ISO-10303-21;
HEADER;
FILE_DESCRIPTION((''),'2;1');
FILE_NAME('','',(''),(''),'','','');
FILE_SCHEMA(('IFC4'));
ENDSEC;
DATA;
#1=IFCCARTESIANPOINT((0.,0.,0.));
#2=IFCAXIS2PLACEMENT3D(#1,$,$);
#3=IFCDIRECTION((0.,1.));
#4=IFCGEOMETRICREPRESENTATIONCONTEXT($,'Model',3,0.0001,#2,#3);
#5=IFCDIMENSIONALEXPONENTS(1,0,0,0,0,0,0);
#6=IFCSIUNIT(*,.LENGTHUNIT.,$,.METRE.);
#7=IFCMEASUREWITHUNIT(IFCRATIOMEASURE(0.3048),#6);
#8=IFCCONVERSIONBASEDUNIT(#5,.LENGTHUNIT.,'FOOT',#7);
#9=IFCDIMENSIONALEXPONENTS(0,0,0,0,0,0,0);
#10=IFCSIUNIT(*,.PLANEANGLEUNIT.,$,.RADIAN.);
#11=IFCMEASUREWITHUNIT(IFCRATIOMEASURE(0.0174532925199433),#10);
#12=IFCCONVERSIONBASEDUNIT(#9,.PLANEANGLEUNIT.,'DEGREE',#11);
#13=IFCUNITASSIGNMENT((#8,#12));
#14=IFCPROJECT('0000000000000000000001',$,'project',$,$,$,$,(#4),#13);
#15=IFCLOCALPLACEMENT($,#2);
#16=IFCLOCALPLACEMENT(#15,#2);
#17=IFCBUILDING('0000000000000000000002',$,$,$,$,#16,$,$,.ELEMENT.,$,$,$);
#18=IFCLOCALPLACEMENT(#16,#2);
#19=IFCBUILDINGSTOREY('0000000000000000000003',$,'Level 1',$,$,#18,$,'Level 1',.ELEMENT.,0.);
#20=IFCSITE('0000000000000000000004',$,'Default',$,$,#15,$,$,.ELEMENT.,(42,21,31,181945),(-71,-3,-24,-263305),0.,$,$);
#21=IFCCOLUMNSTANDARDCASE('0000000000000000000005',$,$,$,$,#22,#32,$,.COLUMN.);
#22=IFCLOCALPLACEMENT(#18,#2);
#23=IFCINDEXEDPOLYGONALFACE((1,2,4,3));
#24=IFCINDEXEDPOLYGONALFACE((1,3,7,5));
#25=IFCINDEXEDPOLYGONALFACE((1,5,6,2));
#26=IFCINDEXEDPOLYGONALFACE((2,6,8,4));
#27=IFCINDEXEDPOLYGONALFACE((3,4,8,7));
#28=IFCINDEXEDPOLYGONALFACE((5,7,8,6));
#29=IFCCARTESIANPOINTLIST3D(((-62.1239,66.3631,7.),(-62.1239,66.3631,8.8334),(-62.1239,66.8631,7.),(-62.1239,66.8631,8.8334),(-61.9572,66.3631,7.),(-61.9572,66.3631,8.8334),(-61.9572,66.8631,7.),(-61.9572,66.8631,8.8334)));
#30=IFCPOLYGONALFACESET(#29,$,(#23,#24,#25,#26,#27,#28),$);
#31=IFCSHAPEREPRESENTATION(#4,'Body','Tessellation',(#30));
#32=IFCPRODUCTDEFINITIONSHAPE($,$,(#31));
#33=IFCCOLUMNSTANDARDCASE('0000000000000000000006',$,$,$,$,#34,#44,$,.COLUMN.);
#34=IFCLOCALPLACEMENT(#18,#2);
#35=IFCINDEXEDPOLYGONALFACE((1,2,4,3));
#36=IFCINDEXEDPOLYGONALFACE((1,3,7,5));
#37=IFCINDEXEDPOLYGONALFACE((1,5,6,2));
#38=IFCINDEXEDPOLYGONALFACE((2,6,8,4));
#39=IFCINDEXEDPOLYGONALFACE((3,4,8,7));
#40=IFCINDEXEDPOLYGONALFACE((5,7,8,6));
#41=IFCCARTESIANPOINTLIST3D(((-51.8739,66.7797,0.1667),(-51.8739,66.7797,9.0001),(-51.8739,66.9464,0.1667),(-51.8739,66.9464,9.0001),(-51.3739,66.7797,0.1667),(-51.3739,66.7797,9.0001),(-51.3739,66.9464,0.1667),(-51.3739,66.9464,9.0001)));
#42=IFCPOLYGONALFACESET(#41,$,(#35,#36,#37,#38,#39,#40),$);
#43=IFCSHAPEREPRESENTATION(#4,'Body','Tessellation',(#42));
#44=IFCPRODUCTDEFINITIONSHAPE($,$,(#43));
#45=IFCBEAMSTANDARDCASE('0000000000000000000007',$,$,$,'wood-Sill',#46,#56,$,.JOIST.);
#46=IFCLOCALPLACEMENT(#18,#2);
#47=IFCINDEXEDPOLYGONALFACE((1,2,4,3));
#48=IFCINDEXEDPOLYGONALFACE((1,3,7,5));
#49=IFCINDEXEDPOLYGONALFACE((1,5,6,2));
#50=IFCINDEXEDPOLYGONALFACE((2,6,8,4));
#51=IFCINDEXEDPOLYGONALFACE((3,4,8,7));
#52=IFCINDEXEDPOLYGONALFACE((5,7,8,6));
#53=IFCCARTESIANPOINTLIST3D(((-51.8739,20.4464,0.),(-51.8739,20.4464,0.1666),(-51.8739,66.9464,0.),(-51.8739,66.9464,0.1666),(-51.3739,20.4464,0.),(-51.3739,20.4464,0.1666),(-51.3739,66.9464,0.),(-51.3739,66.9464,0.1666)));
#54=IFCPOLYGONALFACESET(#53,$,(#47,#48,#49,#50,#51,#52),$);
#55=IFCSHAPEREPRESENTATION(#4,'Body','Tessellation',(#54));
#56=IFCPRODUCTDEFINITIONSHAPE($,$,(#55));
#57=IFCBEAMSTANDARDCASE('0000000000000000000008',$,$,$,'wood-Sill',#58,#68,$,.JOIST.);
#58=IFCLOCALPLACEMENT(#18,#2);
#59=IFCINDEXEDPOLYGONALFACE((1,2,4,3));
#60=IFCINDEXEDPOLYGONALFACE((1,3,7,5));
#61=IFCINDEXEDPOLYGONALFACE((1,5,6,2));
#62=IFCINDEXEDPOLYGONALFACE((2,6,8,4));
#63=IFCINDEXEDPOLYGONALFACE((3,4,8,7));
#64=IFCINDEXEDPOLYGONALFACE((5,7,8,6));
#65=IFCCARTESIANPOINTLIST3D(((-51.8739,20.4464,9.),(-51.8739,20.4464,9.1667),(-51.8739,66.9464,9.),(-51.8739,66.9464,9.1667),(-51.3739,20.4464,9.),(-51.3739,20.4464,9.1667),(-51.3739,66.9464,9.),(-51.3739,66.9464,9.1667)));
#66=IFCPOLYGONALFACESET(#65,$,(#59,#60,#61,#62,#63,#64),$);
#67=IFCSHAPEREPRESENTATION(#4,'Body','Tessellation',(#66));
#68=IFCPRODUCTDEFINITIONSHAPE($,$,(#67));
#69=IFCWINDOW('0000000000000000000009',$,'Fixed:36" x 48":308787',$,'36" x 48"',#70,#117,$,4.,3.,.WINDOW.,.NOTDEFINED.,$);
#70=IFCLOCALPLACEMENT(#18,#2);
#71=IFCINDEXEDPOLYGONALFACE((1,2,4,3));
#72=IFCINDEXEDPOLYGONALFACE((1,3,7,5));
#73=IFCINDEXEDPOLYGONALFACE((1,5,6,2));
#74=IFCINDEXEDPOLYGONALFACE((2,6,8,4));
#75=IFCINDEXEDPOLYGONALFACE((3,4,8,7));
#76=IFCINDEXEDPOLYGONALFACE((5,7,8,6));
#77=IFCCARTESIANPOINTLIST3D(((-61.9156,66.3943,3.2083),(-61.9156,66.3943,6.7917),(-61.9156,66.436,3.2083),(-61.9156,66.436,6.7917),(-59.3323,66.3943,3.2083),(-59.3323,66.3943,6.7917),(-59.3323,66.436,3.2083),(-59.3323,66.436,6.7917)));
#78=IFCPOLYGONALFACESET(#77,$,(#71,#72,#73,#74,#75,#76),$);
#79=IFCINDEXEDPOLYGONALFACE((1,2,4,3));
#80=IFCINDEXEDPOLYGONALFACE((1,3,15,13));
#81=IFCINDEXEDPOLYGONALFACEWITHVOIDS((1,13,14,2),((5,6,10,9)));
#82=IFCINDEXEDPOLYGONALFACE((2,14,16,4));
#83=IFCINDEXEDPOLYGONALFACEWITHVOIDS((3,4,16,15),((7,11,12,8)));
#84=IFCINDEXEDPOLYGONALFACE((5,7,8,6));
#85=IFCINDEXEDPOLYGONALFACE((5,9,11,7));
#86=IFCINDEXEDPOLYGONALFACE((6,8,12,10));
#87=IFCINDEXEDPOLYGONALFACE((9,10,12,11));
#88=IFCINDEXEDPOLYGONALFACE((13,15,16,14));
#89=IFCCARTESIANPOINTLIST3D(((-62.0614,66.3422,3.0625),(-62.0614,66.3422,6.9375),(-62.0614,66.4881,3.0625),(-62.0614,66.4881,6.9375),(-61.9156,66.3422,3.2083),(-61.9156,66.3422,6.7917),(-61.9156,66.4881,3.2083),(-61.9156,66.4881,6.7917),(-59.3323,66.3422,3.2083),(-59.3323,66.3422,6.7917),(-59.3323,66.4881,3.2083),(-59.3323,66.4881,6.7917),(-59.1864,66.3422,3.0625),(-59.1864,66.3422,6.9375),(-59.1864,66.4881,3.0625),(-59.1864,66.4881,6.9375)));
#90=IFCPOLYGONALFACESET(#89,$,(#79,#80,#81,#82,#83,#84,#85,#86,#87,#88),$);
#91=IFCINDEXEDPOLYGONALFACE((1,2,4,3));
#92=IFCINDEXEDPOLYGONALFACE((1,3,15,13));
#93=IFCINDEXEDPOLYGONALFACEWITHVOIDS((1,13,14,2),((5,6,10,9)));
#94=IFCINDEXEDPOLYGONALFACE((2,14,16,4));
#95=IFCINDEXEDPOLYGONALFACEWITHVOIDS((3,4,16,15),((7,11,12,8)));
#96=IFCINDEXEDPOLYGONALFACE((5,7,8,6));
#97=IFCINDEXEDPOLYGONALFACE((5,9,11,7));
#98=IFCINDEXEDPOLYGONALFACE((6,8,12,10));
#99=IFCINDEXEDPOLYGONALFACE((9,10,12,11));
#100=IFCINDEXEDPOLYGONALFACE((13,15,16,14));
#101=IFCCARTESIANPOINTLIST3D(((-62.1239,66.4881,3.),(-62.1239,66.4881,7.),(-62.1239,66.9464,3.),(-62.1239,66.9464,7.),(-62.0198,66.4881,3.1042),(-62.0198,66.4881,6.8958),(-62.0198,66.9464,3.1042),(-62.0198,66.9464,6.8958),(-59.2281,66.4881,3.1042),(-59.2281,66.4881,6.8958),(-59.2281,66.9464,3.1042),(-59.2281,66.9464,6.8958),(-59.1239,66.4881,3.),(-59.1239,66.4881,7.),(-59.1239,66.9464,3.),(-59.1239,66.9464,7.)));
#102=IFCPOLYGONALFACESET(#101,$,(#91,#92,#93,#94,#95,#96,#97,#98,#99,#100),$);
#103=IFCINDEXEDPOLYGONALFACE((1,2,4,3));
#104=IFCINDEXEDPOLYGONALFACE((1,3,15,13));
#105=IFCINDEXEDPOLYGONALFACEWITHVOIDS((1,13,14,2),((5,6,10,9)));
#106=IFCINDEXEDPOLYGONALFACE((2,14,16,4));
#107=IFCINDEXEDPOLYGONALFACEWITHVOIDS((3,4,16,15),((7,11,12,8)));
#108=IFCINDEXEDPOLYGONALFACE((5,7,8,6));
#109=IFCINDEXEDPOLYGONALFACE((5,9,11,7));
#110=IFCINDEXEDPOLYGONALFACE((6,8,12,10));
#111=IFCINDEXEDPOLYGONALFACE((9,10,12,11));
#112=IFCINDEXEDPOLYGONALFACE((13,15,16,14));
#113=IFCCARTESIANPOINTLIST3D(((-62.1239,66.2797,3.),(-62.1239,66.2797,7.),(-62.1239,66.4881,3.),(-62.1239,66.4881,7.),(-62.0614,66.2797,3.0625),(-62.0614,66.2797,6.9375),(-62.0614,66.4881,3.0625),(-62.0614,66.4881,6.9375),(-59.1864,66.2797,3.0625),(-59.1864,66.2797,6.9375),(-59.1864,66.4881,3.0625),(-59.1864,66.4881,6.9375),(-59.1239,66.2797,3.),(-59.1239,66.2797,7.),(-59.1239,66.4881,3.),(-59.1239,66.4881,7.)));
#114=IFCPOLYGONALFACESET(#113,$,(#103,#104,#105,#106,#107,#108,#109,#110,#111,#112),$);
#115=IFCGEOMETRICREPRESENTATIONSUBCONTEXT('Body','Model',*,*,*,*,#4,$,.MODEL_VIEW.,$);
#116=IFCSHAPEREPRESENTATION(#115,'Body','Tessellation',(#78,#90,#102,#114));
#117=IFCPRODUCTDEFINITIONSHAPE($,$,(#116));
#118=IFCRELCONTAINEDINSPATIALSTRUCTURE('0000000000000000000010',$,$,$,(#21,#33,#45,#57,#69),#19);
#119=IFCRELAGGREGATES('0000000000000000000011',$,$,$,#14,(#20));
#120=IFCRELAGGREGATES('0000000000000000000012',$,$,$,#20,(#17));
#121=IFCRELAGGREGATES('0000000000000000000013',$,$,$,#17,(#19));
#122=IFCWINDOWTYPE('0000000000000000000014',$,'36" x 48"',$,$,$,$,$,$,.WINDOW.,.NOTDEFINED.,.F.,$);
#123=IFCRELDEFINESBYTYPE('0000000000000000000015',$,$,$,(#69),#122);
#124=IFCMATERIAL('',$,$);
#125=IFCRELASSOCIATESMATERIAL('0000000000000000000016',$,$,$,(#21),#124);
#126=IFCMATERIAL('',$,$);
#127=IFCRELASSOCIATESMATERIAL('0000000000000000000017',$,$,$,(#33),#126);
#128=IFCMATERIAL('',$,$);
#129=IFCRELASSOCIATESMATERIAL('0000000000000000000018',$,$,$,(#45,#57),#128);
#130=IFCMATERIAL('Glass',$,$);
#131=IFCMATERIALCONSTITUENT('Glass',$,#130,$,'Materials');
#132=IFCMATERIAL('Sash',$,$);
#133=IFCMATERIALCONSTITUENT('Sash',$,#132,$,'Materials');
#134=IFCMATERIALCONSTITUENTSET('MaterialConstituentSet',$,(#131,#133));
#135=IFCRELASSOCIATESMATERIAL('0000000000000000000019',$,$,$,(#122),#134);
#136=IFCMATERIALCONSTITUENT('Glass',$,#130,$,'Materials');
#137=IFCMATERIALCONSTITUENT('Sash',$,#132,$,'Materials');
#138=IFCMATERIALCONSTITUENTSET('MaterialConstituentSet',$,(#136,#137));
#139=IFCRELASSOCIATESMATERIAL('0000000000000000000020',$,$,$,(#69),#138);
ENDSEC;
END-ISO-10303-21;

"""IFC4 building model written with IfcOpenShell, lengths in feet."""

from ifc_helpers import new_model, entity, si_unit, converted_unit, direction, frame, frame_2d, origin, origin_with_axes, place, context, subcontext, project, spatial, polyline, rectangle, outline, extrude, source, transform, mapped, material, constituent, constituent_set, type_object, type_shapes, element, save


model = new_model("IFC4")

# Units and contexts
model_context = context("Model", 3, precision=0.0001, world=origin(), true_north=direction((0.0, 1.0)))
body_context = subcontext(model_context, "Body", "Model", "MODEL_VIEW")
ifc_project = project(units=[converted_unit("LENGTHUNIT", "FOOT", entity("IfcRatioMeasure", 0.3048), si_unit("LENGTHUNIT", "METRE"), dimensions=[1, 0, 0, 0, 0, 0, 0]), converted_unit("PLANEANGLEUNIT", "DEGREE", entity("IfcRatioMeasure", 0.0174532925199433), si_unit("PLANEANGLEUNIT", "RADIAN"), dimensions=[0, 0, 0, 0, 0, 0, 0])], contexts=[model_context])

# Site, building, storey
site_placement = place(None, origin())
site = spatial("IfcSite", under=ifc_project, at=site_placement, Name="Default", CompositionType="ELEMENT", RefLatitude=(42, 21, 31, 181945), RefLongitude=(-71, -3, -24, -263305), RefElevation=0.0)
building_placement = place(site_placement, origin())
building = spatial("IfcBuilding", under=site, at=building_placement, CompositionType="ELEMENT")
storey_placement = place(building_placement, origin())
storey = spatial("IfcBuildingStorey", under=building, at=storey_placement, Name="Level 1", LongName="Level 1", CompositionType="ELEMENT", Elevation=0.0)

# Columns
ifc_material_1 = material(Name="")
placement_1 = place(storey_placement, frame((-69.9573, 66.6131, 0.0)))
ifc_material_2 = material(Name="")
for number, where, z_axis, x_axis in (
    (1, (7.9167, 0.0, 7.0), (0.0, 0.0, 1.0), (1.0, 0.0, 0.0)),
):
    element("IfcColumnStandardCase", number, at=place(placement_1, frame(where, z_axis=z_axis, x_axis=x_axis)), inside=storey, material=ifc_material_2, PredefinedType="COLUMN", context=model_context, shape_type="SweptSolid", body=[
        extrude(rectangle(XDim=0.1667, YDim=0.5), origin(), (0.0, 0.0, 1.0), 1.8334),
    ])
placement_2 = place(storey_placement, frame((-51.6239, 66.9464, 0.0), z_axis=(0.0, 0.0, 1.0), x_axis=(0.0, -1.0, 0.0)))
for number, where, z_axis, x_axis in (
    (2, (0.0833, 0.0, 0.1667), (0.0, 0.0, 1.0), (1.0, 0.0, 0.0)),
):
    element("IfcColumnStandardCase", number, at=place(placement_2, frame(where, z_axis=z_axis, x_axis=x_axis)), inside=storey, material=ifc_material_1, PredefinedType="COLUMN", context=model_context, shape_type="SweptSolid", body=[
        extrude(rectangle(XDim=0.1667, YDim=0.5), origin(), (0.0, 0.0, 1.0), 8.8334),
    ])

# Beams
ifc_material_3 = material(Name="")
for number, where, z_axis, x_axis in (
    (3, (0.0, 0.0, 0.0833), (1.0, 0.0, 0.0), (0.0, 0.0, 1.0)),
    (4, (0.0, 0.0, 9.0834), (1.0, 0.0, 0.0), (0.0, 0.0, 1.0)),
):
    element("IfcBeamStandardCase", number, at=place(placement_2, frame(where, z_axis=z_axis, x_axis=x_axis)), inside=storey, material=ifc_material_3, ObjectType="wood-Sill", PredefinedType="JOIST", context=model_context, shape_type="SweptSolid", body=[
        extrude(rectangle(XDim=0.1667, YDim=0.5), origin_with_axes(), (0.0, 0.0, 1.0), 46.5),
    ])

# Window
ifc_material_4 = material(Name="Glass")
ifc_constituent_1 = constituent(ifc_material_4, Name="Glass", Category="Materials")
ifc_material_5 = material(Name="Sash")
ifc_constituent_2 = constituent(ifc_material_5, Name="Sash", Category="Materials")
ifc_constituent_set_1 = constituent_set(constituents=[ifc_constituent_1, ifc_constituent_2], Name="MaterialConstituentSet")
ifc_constituent_3 = constituent(ifc_material_4, Name="Glass", Category="Materials")
ifc_constituent_4 = constituent(ifc_material_5, Name="Sash", Category="Materials")
ifc_constituent_set_2 = constituent_set(constituents=[ifc_constituent_3, ifc_constituent_4], Name="MaterialConstituentSet")
window_type = type_object("IfcWindowType", Name="36\" x 48\"", ParameterTakesPrecedence=False, PartitioningType="NOTDEFINED", PredefinedType="WINDOW", material=ifc_constituent_set_2)
shared_shape = source(origin(), body_context, "Body", "SweptSolid", [
    extrude(rectangle(XDim=0.0417, YDim=2.5833, at=frame_2d((0.0, 0.0), x_axis=(1.0, 0.0))), frame((1.5, 0.5312, 0.2083), z_axis=(0.0, 0.0, 1.0), x_axis=(0.0, 1.0, 0.0)), (0.0, 0.0, 1.0), 3.5833),
    extrude(outline(polyline([(-1.4375, -1.9375), (1.4375, -1.9375), (1.4375, 1.9375), (-1.4375, 1.9375), (-1.4375, -1.9375)]), holes=[polyline([(-1.2917, -1.7917), (-1.2917, 1.7917), (1.2917, 1.7917), (1.2917, -1.7917), (-1.2917, -1.7917)])]), frame((1.5, 0.4583, 2.0), z_axis=(0.0, 1.0, 0.0), x_axis=(1.0, 0.0, 0.0)), (0.0, 0.0, 1.0), 0.1458),
    extrude(outline(polyline([(-1.5, -2.0), (1.5, -2.0), (1.5, 2.0), (-1.5, 2.0), (-1.5, -2.0)]), holes=[polyline([(-1.3958, -1.8958), (-1.3958, 1.8958), (1.3958, 1.8958), (1.3958, -1.8958), (-1.3958, -1.8958)])]), frame((1.5, 0.0, 2.0), z_axis=(0.0, 1.0, 0.0), x_axis=(1.0, 0.0, 0.0)), (0.0, 0.0, 1.0), 0.4583),
    extrude(outline(polyline([(-2.0, -1.5), (2.0, -1.5), (2.0, 1.5), (-2.0, 1.5), (-2.0, -1.5)]), holes=[polyline([(-1.9375, -1.4375), (-1.9375, 1.4375), (1.9375, 1.4375), (1.9375, -1.4375), (-1.9375, -1.4375)])]), frame((1.5, 0.4583, 2.0), z_axis=(0.0, 1.0, 0.0), x_axis=(0.0, 0.0, -1.0)), (0.0, 0.0, 1.0), 0.2083),
])
type_shapes(window_type, [shared_shape])
placement_3 = place(placement_1, frame((10.8333, 0.3333, 3.0)))
window_placement = place(placement_3, frame((0.0, 0.0, 0.0), z_axis=(0.0, 0.0, 1.0), x_axis=(-1.0, 0.0, 0.0)))
element("IfcWindow", 5, at=window_placement, inside=storey, type_object=window_type, material=ifc_constituent_set_1, Name="Fixed:36\" x 48\":308787", ObjectType="36\" x 48\"", OverallHeight=4.0, OverallWidth=3.0, PartitioningType="NOTDEFINED", PredefinedType="WINDOW", context=body_context, shape_type="MappedRepresentation", body=[
    mapped(shared_shape, transform((0.0, 0.0, 0.0), scale=1.0)),
])

save(model, "model.ifc")
